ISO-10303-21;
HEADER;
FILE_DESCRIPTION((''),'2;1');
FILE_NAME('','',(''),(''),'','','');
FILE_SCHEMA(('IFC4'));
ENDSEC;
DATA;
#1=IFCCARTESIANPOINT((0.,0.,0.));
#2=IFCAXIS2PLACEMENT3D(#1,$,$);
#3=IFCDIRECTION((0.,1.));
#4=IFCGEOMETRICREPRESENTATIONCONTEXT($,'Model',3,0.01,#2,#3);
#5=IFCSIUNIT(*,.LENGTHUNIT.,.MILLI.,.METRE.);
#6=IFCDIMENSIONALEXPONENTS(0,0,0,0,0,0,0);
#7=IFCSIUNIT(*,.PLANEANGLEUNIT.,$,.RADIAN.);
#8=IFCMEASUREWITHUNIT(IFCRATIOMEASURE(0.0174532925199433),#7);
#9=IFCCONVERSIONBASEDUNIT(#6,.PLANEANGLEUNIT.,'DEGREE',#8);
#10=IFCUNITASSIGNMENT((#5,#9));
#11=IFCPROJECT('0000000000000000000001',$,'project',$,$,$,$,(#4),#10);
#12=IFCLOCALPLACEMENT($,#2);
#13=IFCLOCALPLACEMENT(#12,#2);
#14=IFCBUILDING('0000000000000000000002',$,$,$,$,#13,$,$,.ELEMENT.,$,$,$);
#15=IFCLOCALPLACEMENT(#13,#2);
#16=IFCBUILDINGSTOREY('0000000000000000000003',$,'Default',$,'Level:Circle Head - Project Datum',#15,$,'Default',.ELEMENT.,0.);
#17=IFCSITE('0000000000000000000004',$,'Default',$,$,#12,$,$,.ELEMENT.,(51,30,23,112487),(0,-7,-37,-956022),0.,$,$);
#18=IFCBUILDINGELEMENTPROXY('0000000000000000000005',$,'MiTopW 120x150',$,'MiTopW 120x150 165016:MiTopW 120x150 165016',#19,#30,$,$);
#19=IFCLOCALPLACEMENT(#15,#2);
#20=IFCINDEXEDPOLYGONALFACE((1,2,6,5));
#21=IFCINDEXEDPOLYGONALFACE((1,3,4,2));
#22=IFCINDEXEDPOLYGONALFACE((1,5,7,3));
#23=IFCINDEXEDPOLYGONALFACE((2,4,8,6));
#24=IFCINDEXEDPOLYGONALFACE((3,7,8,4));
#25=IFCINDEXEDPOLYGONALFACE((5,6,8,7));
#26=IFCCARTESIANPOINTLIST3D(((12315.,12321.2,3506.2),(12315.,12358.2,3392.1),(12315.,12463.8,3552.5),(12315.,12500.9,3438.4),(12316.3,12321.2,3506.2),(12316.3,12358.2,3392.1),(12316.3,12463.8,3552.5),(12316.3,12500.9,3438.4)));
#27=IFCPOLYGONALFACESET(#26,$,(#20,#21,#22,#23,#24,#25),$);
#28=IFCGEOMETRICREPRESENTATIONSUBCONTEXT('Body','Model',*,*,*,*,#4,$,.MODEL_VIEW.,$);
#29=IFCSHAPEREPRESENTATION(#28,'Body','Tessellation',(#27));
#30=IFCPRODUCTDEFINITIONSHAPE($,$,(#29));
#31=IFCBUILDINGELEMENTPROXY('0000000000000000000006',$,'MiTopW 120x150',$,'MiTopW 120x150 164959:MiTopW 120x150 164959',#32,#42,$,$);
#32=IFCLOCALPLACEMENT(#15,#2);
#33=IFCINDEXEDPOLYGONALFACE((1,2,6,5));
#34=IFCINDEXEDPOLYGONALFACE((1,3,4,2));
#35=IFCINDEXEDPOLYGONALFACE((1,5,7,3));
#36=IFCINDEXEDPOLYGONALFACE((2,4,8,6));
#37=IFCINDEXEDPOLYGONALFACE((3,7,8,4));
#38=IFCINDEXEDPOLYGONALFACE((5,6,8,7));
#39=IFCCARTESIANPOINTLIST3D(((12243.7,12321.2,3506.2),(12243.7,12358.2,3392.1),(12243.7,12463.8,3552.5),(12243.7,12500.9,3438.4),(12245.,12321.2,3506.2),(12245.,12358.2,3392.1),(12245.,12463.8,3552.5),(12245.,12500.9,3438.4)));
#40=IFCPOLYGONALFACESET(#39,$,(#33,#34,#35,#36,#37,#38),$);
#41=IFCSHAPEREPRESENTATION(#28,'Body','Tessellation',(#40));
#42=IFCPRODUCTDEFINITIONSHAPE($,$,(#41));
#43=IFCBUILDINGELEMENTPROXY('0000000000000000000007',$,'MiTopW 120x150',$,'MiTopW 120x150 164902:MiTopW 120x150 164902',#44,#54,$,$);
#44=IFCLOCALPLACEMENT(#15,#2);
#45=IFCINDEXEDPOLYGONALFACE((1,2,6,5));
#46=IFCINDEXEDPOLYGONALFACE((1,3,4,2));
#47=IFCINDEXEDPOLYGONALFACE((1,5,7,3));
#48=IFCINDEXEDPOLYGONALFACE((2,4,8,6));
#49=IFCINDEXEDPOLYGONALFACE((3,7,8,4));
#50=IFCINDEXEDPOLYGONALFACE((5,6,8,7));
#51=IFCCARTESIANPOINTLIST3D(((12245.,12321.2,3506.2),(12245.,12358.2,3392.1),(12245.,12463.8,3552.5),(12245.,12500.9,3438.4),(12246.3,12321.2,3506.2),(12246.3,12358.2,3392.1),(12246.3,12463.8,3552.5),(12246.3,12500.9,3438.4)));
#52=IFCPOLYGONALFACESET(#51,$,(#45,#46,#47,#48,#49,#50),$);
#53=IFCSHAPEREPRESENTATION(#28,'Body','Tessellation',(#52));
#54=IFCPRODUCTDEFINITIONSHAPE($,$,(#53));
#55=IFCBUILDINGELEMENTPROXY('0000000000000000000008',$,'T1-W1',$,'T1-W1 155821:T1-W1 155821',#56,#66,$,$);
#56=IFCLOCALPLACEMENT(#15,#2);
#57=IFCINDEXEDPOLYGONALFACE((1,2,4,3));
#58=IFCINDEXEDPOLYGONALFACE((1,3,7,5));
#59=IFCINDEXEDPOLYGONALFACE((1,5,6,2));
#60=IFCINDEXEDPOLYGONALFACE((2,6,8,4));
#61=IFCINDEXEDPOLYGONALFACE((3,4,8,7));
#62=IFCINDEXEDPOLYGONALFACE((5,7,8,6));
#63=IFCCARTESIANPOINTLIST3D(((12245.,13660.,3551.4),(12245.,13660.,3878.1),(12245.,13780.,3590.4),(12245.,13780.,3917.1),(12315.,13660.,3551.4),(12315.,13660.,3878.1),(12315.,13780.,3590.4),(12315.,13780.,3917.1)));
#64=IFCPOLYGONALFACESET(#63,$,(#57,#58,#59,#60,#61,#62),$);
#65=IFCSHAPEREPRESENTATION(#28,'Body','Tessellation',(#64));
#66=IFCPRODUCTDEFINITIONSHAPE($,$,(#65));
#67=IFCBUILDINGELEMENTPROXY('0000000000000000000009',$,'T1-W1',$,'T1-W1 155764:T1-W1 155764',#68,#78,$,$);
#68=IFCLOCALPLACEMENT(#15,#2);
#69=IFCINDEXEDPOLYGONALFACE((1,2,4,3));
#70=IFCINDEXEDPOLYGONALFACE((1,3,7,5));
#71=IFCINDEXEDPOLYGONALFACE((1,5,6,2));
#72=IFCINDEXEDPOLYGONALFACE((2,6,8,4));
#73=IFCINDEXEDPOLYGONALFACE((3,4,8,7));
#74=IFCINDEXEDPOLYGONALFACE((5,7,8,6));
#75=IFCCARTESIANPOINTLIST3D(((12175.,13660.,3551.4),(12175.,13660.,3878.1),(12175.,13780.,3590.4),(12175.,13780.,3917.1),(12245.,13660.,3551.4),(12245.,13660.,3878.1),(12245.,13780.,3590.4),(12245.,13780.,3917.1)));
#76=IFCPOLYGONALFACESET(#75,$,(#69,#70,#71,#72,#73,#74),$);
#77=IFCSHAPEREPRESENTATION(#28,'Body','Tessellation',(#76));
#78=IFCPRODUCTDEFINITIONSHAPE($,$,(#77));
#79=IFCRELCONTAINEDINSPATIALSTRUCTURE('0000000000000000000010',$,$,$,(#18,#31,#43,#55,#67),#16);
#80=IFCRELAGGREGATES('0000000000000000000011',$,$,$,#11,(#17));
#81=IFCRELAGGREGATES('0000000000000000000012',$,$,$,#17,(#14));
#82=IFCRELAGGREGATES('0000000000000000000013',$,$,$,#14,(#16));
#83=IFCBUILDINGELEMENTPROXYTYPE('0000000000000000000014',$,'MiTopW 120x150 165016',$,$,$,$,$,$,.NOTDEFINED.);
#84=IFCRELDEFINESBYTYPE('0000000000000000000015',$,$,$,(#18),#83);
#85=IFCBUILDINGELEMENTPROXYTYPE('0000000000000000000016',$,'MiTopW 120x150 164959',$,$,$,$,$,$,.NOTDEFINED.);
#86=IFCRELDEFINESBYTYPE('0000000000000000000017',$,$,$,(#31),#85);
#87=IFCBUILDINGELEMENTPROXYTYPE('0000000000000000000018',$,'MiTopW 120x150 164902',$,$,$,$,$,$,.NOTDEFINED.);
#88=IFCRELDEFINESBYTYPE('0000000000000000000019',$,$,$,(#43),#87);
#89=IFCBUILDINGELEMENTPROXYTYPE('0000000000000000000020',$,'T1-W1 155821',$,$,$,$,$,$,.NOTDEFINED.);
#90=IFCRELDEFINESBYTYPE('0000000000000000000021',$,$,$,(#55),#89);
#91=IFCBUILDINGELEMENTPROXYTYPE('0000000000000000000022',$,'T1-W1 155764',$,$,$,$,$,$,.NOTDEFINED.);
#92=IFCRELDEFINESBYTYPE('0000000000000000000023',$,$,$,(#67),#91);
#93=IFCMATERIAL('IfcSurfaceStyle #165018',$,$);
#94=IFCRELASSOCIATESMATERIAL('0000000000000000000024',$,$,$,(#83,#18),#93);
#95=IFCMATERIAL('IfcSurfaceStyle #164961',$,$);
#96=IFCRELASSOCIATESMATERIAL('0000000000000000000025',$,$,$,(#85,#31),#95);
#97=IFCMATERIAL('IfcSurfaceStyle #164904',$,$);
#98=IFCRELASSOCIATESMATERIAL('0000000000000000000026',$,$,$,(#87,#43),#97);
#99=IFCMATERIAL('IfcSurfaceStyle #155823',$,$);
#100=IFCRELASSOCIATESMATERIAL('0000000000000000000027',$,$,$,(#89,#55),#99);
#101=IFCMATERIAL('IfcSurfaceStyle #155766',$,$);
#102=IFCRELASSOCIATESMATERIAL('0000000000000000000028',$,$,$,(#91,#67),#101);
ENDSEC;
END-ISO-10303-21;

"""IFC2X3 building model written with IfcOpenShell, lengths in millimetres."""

from ifc_helpers import new_model, entity, si_unit, converted_unit, direction, frame, origin, place, context, subcontext, project, spatial, polyline, outline, extrude, source, transform, mapped, material, type_object, type_shapes, element, save


model = new_model("IFC2X3")

# Units and contexts
model_context = context("Model", 3, precision=0.01, world=origin(), true_north=direction((0.0, 1.0)))
body_context = subcontext(model_context, "Body", "Model", "MODEL_VIEW")
ifc_project = project(units=[si_unit("LENGTHUNIT", "METRE", prefix="MILLI"), converted_unit("PLANEANGLEUNIT", "DEGREE", entity("IfcRatioMeasure", 0.0174532925199433), si_unit("PLANEANGLEUNIT", "RADIAN"), dimensions=[0, 0, 0, 0, 0, 0, 0])], contexts=[model_context])

# Site, building, storey
site_placement = place(None, origin())
site = spatial("IfcSite", under=ifc_project, at=site_placement, Name="Default", CompositionType="ELEMENT", RefLatitude=(51, 30, 23, 112487), RefLongitude=(0, -7, -37, -956022), RefElevation=0.0)
building_placement = place(site_placement, origin())
building = spatial("IfcBuilding", under=site, at=building_placement, CompositionType="ELEMENT")
storey_placement = place(building_placement, origin())
storey = spatial("IfcBuildingStorey", under=building, at=storey_placement, Name="Default", ObjectType="Level:Circle Head - Project Datum", LongName="Default", CompositionType="ELEMENT", Elevation=0.0)

# Building element proxies
ifc_material_1 = material(Name="IfcSurfaceStyle #165018")
building_element_proxy_type_1 = type_object("IfcBuildingElementProxyType", Name="MiTopW 120x150 165016", PredefinedType="NOTDEFINED", material=ifc_material_1)
shared_shape_1 = source(origin(), body_context, "Body", "SweptSolid", [
    extrude(outline(polyline([(-75.0, -60.0), (75.0, -60.0), (75.0, 60.0), (-75.0, 60.0), (-75.0, -60.0)])), frame((75.0, 60.0, 0.0), z_axis=(0.0, 0.0, 1.0), x_axis=(-1.0, 0.0, 0.0)), (0.0, 0.0, 1.0), 1.3),
])
type_shapes(building_element_proxy_type_1, [shared_shape_1])
proxy_1_placement = place(building_placement, frame((12316.3, 12321.2, 3506.2), z_axis=(-1.0, 0.0, 0.0), x_axis=(0.0, 0.951057, 0.309017)))
element("IfcBuildingElementProxy", 1, at=proxy_1_placement, inside=storey, type_object=building_element_proxy_type_1, material=ifc_material_1, Name="MiTopW 120x150", ObjectType="MiTopW 120x150 165016:MiTopW 120x150 165016", context=body_context, shape_type="MappedRepresentation", body=[
    mapped(shared_shape_1, transform((0.0, 0.0, 0.0), scale=1.0)),
])
ifc_material_2 = material(Name="IfcSurfaceStyle #164961")
building_element_proxy_type_2 = type_object("IfcBuildingElementProxyType", Name="MiTopW 120x150 164959", PredefinedType="NOTDEFINED", material=ifc_material_2)
shared_shape_2 = source(origin(), body_context, "Body", "SweptSolid", [
    extrude(outline(polyline([(-75.0, -60.0), (75.0, -60.0), (75.0, 60.0), (-75.0, 60.0), (-75.0, -60.0)])), frame((75.0, 60.0, 0.0), z_axis=(0.0, 0.0, 1.0), x_axis=(-1.0, 0.0, 0.0)), (0.0, 0.0, 1.0), 1.3),
])
type_shapes(building_element_proxy_type_2, [shared_shape_2])
proxy_2_placement = place(building_placement, frame((12245.0, 12321.2, 3506.2), z_axis=(-1.0, 0.0, 0.0), x_axis=(0.0, 0.951057, 0.309017)))
element("IfcBuildingElementProxy", 2, at=proxy_2_placement, inside=storey, type_object=building_element_proxy_type_2, material=ifc_material_2, Name="MiTopW 120x150", ObjectType="MiTopW 120x150 164959:MiTopW 120x150 164959", context=body_context, shape_type="MappedRepresentation", body=[
    mapped(shared_shape_2, transform((0.0, 0.0, 0.0), scale=1.0)),
])
ifc_material_3 = material(Name="IfcSurfaceStyle #164904")
building_element_proxy_type_3 = type_object("IfcBuildingElementProxyType", Name="MiTopW 120x150 164902", PredefinedType="NOTDEFINED", material=ifc_material_3)
shared_shape_3 = source(origin(), body_context, "Body", "SweptSolid", [
    extrude(outline(polyline([(-75.0, -60.0), (75.0, -60.0), (75.0, 60.0), (-75.0, 60.0), (-75.0, -60.0)])), frame((75.0, 60.0, 0.0), z_axis=(0.0, 0.0, 1.0), x_axis=(-1.0, 0.0, 0.0)), (0.0, 0.0, 1.0), 1.3),
])
type_shapes(building_element_proxy_type_3, [shared_shape_3])
proxy_3_placement = place(building_placement, frame((12246.3, 12321.2, 3506.2), z_axis=(-1.0, 0.0, 0.0), x_axis=(0.0, 0.951057, 0.309017)))
element("IfcBuildingElementProxy", 3, at=proxy_3_placement, inside=storey, type_object=building_element_proxy_type_3, material=ifc_material_3, Name="MiTopW 120x150", ObjectType="MiTopW 120x150 164902:MiTopW 120x150 164902", context=body_context, shape_type="MappedRepresentation", body=[
    mapped(shared_shape_3, transform((0.0, 0.0, 0.0), scale=1.0)),
])
ifc_material_4 = material(Name="IfcSurfaceStyle #155823")
building_element_proxy_type_4 = type_object("IfcBuildingElementProxyType", Name="T1-W1 155821", PredefinedType="NOTDEFINED", material=ifc_material_4)
shared_shape_4 = source(origin(), body_context, "Body", "SweptSolid", [
    extrude(outline(polyline([(-182.8, -60.0), (143.8, -60.0), (182.8, 60.0), (-143.8, 60.0), (-182.8, -60.0)])), frame((182.8, 60.0, 0.0), z_axis=(0.0, 0.0, 1.0), x_axis=(-1.0, 0.0, 0.0)), (0.0, 0.0, 1.0), 70.0),
])
type_shapes(building_element_proxy_type_4, [shared_shape_4])
proxy_4_placement = place(building_placement, frame((12315.0, 13660.0, 3551.4), z_axis=(-1.0, 0.0, 0.0), x_axis=(0.0, 0.0, 1.0)))
element("IfcBuildingElementProxy", 4, at=proxy_4_placement, inside=storey, type_object=building_element_proxy_type_4, material=ifc_material_4, Name="T1-W1", ObjectType="T1-W1 155821:T1-W1 155821", context=body_context, shape_type="MappedRepresentation", body=[
    mapped(shared_shape_4, transform((0.0, 0.0, 0.0), scale=1.0)),
])
ifc_material_5 = material(Name="IfcSurfaceStyle #155766")
building_element_proxy_type_5 = type_object("IfcBuildingElementProxyType", Name="T1-W1 155764", PredefinedType="NOTDEFINED", material=ifc_material_5)
shared_shape_5 = source(origin(), body_context, "Body", "SweptSolid", [
    extrude(outline(polyline([(-182.8, -60.0), (143.8, -60.0), (182.8, 60.0), (-143.8, 60.0), (-182.8, -60.0)])), frame((182.8, 60.0, 0.0), z_axis=(0.0, 0.0, 1.0), x_axis=(-1.0, 0.0, 0.0)), (0.0, 0.0, 1.0), 70.0),
])
type_shapes(building_element_proxy_type_5, [shared_shape_5])
proxy_5_placement = place(building_placement, frame((12245.0, 13660.0, 3551.4), z_axis=(-1.0, 0.0, 0.0), x_axis=(0.0, 0.0, 1.0)))
element("IfcBuildingElementProxy", 5, at=proxy_5_placement, inside=storey, type_object=building_element_proxy_type_5, material=ifc_material_5, Name="T1-W1", ObjectType="T1-W1 155764:T1-W1 155764", context=body_context, shape_type="MappedRepresentation", body=[
    mapped(shared_shape_5, transform((0.0, 0.0, 0.0), scale=1.0)),
])

save(model, "model.ifc")
